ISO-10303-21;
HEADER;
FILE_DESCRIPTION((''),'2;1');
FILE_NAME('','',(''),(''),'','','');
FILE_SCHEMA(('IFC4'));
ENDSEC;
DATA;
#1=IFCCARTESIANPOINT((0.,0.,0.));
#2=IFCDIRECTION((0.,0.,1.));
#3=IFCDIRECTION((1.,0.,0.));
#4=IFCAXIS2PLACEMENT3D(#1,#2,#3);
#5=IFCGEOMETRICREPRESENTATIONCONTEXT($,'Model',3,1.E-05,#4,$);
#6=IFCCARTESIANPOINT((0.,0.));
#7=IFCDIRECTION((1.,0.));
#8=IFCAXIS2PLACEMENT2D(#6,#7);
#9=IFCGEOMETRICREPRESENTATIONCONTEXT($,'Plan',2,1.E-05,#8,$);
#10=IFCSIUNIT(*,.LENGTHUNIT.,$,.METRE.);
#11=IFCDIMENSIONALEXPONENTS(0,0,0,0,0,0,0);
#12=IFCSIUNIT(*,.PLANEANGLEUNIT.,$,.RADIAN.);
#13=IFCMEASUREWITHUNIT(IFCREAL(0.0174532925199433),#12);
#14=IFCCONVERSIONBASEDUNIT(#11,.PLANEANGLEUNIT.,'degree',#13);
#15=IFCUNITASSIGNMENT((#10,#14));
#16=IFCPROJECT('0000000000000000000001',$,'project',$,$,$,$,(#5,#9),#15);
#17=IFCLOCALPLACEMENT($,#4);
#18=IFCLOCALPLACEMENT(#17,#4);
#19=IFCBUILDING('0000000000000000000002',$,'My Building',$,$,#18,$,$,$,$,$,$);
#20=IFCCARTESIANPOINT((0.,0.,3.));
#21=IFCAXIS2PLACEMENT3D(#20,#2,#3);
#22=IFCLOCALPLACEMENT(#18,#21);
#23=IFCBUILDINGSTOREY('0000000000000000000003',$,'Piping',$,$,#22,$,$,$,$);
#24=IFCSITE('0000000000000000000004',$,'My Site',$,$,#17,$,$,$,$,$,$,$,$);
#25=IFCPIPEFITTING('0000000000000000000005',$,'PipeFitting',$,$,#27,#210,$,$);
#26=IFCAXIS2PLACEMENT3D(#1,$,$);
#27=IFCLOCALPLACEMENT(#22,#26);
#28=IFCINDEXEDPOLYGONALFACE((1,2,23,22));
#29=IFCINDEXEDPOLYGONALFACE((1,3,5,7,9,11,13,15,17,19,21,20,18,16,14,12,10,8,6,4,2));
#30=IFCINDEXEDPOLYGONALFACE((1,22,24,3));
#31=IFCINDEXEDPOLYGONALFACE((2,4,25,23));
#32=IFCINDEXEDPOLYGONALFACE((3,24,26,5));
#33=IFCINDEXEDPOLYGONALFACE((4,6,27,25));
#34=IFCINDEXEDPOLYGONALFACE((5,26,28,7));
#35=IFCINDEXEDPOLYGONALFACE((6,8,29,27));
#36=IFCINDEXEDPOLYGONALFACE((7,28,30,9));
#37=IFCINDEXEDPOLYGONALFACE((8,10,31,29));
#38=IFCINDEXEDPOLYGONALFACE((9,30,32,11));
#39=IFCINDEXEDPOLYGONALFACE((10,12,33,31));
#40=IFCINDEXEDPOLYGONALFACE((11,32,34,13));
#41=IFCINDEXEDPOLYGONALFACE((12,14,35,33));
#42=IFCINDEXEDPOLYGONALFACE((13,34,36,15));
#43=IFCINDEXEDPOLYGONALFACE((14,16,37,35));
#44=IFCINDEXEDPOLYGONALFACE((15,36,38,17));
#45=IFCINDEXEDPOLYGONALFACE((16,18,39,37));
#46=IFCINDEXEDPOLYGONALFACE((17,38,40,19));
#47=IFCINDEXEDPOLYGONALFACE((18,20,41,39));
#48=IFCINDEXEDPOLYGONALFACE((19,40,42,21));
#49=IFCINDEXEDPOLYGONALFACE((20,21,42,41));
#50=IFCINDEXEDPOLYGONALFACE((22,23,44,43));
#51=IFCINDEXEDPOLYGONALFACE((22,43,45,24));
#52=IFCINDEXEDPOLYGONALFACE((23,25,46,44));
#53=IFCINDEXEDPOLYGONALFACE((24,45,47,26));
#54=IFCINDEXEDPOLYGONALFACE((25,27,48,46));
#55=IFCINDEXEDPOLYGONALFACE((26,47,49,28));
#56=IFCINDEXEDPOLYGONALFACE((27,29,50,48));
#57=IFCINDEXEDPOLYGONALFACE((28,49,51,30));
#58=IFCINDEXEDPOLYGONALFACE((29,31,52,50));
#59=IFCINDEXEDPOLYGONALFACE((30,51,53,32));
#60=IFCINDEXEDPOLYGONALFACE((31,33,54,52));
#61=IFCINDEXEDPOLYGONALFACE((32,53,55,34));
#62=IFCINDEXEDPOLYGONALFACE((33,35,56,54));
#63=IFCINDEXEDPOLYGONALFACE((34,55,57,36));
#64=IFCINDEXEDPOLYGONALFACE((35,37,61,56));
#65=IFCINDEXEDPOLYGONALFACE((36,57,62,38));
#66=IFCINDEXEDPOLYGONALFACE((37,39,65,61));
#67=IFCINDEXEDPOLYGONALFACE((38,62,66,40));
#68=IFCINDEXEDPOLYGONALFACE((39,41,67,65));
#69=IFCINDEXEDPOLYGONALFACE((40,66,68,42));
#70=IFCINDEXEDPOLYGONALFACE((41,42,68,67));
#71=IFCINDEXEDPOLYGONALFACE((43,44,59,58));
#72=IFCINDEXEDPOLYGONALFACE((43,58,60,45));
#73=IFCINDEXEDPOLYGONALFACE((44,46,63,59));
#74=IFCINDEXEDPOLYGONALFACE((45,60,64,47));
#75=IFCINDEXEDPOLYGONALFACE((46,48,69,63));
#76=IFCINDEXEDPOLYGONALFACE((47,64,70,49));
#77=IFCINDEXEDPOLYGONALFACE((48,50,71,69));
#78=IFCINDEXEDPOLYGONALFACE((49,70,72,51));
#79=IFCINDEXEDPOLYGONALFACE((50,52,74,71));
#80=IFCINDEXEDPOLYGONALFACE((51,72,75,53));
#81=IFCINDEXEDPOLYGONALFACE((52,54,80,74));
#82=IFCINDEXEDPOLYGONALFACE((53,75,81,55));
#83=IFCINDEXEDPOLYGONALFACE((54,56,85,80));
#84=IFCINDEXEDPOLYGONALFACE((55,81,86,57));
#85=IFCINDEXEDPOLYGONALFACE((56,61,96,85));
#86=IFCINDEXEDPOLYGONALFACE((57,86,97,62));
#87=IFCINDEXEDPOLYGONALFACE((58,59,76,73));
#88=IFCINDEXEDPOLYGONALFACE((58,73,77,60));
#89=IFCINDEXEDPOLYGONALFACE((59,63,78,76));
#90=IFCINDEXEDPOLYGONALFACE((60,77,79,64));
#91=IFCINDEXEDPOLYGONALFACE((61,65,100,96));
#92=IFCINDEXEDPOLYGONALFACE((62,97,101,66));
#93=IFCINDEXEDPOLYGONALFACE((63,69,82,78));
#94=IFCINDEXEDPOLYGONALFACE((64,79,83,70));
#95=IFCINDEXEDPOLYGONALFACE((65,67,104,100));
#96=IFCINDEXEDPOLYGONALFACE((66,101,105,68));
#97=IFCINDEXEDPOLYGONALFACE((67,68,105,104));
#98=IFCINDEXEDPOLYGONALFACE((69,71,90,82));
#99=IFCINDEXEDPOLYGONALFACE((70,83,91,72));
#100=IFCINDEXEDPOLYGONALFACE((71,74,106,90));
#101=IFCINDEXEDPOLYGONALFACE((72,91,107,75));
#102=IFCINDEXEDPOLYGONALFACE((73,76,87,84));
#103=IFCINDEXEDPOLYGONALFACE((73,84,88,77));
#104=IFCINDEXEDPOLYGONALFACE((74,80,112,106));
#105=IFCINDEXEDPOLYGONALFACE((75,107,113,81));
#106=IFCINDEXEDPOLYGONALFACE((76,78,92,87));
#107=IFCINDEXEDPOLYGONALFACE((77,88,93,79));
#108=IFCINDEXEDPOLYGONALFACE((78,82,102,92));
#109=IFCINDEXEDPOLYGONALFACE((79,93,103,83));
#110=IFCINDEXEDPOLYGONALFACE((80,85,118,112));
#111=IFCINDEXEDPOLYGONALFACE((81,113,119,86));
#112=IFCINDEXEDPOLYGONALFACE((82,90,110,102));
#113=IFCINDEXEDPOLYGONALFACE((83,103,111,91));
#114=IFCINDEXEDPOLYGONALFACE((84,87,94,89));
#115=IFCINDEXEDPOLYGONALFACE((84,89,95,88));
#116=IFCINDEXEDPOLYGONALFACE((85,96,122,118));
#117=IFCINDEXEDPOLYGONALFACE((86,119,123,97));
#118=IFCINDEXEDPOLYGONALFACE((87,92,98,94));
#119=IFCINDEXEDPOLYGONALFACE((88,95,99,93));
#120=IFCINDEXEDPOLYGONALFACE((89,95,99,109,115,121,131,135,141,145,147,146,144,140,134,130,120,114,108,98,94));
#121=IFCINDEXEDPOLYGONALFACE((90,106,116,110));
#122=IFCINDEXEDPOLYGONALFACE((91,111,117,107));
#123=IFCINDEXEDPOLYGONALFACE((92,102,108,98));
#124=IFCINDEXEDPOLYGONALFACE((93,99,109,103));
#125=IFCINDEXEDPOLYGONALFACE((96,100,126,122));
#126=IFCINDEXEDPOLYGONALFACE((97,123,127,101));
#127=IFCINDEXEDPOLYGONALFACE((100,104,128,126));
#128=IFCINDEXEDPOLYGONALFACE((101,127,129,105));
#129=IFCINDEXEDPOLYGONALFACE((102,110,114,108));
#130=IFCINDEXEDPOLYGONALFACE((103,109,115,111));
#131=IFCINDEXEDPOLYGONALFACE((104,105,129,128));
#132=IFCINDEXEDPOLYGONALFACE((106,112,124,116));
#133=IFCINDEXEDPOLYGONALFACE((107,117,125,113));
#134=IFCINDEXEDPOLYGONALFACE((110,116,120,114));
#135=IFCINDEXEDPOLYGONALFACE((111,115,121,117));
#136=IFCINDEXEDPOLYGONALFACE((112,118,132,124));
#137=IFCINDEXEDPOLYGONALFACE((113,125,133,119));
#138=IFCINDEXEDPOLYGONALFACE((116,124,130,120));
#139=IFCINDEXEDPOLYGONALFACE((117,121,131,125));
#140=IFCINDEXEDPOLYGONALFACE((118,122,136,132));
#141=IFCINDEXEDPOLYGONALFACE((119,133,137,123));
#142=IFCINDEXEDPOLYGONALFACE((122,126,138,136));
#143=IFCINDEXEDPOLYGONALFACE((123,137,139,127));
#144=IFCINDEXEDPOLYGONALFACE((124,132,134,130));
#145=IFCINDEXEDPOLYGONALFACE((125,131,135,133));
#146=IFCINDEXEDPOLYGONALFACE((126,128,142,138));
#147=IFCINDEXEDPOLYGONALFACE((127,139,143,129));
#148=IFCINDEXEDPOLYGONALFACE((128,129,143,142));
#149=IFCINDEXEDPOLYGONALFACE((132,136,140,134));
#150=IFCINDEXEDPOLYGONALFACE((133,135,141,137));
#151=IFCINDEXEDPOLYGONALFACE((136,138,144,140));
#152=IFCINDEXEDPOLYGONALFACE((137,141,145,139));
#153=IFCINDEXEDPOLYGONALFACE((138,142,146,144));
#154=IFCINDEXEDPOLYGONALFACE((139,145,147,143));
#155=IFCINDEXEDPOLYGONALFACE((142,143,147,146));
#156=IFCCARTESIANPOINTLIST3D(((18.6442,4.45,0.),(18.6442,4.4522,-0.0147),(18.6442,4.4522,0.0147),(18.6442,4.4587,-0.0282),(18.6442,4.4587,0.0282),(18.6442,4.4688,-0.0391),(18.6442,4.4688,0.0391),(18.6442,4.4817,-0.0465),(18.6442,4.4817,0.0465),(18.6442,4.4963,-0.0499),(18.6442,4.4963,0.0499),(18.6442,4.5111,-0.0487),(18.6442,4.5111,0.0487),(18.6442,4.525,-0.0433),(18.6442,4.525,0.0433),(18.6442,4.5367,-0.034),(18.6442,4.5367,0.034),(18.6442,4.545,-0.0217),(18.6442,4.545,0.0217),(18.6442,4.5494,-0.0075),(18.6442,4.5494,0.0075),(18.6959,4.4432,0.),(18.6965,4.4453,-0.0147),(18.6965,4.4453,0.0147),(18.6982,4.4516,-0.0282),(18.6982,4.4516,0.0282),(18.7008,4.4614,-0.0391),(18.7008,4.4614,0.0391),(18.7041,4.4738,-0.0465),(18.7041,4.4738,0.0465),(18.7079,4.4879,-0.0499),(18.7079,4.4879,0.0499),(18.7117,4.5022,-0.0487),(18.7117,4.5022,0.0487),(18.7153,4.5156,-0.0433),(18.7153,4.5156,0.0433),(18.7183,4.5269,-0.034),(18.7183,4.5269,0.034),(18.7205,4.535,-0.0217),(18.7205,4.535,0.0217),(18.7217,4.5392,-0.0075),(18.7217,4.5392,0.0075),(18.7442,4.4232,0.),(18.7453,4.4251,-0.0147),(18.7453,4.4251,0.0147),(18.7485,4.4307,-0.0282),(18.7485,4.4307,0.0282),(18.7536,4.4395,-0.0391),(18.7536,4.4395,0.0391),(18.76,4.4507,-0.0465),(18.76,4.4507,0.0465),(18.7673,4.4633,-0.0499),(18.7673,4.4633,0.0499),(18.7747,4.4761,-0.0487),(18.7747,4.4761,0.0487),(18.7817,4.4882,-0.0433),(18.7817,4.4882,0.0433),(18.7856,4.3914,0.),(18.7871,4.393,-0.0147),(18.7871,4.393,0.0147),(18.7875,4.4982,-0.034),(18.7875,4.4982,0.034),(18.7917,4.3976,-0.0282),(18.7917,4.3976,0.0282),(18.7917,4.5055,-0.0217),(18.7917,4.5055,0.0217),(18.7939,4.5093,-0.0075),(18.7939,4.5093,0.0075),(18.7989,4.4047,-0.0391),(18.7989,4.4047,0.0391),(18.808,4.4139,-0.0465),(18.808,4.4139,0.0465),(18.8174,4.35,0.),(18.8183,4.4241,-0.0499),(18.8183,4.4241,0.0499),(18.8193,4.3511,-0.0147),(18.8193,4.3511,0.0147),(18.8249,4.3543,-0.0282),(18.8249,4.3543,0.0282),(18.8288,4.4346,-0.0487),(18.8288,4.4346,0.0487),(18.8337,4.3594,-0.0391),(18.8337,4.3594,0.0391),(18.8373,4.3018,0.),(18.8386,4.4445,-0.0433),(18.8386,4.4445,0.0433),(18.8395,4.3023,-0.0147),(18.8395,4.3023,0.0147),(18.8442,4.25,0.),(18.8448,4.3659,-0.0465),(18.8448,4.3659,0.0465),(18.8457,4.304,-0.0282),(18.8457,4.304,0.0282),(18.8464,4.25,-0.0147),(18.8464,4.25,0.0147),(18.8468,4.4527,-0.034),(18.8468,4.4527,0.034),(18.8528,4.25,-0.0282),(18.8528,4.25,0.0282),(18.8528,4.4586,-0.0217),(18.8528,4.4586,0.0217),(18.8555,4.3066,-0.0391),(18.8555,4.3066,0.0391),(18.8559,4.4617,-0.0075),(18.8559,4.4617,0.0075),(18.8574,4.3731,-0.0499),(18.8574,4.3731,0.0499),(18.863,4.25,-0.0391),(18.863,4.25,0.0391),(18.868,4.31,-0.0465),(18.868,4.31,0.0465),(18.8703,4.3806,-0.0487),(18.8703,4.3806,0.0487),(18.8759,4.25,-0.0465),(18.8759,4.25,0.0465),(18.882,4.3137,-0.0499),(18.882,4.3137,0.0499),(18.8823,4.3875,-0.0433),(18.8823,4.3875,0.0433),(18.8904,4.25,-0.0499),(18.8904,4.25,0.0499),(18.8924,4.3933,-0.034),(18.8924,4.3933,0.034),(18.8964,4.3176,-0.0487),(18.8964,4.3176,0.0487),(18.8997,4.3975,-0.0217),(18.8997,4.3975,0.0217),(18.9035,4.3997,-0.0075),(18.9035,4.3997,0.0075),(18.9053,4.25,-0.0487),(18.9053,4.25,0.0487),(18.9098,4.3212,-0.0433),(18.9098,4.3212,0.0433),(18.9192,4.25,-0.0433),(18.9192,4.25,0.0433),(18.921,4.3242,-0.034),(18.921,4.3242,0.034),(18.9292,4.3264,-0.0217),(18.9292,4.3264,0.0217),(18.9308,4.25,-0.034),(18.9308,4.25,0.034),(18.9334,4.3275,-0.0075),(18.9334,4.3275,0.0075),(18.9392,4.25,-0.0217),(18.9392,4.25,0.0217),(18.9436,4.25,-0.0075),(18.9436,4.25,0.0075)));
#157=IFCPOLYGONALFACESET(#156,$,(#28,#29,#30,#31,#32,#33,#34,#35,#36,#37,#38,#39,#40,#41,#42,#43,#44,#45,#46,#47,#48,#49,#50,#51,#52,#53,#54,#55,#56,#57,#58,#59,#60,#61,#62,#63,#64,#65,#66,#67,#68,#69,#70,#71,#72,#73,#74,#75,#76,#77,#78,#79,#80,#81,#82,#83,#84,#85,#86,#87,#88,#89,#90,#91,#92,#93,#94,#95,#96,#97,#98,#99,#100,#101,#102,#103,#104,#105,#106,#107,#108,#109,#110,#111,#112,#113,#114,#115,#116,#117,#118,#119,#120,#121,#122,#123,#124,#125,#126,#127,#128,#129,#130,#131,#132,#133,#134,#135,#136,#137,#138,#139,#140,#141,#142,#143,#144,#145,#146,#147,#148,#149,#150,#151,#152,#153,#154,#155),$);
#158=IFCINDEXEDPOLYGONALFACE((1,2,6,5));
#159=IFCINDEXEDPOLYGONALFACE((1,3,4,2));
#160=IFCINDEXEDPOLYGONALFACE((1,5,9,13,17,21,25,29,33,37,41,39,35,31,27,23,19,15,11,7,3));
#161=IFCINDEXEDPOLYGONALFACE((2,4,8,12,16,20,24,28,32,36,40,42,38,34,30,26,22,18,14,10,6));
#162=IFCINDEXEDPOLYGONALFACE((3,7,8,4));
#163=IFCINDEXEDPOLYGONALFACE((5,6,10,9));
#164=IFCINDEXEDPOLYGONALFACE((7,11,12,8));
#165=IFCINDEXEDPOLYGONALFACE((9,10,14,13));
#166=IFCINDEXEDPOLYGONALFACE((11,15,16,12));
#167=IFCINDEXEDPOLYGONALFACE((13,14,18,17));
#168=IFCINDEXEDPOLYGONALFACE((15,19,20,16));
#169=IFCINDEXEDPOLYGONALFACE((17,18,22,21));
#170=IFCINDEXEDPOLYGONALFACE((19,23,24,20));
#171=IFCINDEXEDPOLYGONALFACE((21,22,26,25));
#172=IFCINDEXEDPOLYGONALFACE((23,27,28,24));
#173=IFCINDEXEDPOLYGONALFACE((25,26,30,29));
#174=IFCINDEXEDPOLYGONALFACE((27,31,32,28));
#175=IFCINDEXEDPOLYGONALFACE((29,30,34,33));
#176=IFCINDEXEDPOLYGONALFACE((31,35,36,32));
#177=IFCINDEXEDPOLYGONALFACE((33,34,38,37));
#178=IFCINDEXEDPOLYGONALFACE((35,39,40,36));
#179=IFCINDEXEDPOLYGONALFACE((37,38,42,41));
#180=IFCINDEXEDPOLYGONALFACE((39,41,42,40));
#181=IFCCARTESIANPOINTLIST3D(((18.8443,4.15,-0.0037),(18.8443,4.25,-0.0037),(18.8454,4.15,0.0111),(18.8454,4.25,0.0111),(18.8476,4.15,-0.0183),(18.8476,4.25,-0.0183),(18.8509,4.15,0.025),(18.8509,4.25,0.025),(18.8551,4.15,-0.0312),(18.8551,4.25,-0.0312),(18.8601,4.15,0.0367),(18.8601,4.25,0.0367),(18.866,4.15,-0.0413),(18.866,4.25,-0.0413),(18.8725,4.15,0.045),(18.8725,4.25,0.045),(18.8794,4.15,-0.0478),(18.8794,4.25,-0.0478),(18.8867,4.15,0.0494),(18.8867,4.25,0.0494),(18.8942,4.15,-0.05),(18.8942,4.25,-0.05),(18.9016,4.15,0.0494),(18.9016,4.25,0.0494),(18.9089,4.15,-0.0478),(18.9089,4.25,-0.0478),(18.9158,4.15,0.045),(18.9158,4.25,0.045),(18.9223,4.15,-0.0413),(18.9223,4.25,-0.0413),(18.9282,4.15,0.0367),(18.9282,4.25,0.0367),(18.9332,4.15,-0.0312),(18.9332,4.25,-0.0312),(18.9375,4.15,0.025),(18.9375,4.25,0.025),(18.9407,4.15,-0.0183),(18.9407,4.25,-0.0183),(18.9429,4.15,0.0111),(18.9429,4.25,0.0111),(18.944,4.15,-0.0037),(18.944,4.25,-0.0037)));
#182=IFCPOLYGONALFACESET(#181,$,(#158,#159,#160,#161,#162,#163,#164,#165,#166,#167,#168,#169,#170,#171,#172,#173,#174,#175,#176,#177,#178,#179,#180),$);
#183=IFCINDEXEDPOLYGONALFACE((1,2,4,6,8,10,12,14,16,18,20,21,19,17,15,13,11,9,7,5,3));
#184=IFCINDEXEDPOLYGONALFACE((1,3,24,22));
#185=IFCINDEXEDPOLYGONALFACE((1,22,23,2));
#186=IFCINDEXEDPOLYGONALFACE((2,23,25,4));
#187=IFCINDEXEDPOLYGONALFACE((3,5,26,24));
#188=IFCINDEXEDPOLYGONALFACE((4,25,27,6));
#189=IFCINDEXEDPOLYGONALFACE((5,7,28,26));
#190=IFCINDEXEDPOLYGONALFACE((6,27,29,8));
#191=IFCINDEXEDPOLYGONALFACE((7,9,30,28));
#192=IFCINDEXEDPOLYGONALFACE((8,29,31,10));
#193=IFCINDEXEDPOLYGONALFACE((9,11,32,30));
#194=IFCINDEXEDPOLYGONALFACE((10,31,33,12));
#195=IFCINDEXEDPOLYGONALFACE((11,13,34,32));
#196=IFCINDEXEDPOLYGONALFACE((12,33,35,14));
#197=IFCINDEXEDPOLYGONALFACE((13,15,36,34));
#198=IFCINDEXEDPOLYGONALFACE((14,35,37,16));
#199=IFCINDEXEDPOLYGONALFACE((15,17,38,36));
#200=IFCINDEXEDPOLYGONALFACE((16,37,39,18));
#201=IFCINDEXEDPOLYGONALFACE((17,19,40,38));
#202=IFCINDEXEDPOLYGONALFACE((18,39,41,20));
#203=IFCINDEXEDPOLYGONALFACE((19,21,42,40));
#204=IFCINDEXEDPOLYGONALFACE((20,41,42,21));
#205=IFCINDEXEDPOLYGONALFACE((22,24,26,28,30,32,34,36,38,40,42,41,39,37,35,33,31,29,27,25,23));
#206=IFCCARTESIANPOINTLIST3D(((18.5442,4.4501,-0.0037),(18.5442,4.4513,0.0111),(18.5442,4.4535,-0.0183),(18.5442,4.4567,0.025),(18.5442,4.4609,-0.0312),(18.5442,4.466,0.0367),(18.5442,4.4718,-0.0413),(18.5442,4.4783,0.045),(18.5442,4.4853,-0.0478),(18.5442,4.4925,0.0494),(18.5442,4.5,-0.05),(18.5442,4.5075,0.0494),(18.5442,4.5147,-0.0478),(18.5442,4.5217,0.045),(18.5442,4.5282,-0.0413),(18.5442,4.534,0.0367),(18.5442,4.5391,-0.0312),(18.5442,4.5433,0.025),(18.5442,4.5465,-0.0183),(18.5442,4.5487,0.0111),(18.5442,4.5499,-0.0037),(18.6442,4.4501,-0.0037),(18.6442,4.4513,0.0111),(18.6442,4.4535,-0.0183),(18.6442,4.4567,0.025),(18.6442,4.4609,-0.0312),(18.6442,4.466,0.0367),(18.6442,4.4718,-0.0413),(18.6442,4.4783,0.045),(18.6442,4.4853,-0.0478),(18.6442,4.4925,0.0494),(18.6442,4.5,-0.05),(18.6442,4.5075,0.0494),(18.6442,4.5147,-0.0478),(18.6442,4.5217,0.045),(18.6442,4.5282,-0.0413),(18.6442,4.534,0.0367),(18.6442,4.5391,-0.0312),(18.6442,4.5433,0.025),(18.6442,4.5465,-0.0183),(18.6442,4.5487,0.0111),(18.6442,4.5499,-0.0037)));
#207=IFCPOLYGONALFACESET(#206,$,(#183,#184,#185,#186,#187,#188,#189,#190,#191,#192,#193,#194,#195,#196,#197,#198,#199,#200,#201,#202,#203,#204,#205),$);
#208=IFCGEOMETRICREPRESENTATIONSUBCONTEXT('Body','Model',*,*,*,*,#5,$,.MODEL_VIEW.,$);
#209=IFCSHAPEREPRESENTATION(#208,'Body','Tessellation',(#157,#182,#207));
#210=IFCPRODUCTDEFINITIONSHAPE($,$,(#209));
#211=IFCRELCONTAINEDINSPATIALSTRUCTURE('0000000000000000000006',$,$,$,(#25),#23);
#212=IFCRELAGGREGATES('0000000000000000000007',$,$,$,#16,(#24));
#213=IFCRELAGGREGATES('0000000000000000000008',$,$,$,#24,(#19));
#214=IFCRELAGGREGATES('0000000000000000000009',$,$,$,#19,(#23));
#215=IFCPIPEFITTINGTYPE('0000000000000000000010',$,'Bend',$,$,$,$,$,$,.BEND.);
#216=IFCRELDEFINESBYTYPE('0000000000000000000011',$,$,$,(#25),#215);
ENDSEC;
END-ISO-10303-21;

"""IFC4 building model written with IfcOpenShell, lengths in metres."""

from ifc_helpers import new_model, entity, si_unit, converted_unit, frame, origin_with_axes, origin_2d_with_axis, place, context, subcontext, project, spatial, circle, extrude, source, transform, mapped, type_object, type_shapes, element, save


model = new_model("IFC4")

# Units and contexts
model_context = context("Model", 3, precision=1e-05, world=origin_with_axes())
plan_context = context("Plan", 2, precision=1e-05, world=origin_2d_with_axis())
body_context = subcontext(model_context, "Body", "Model", "MODEL_VIEW")
ifc_project = project(units=[si_unit("LENGTHUNIT", "METRE"), converted_unit("PLANEANGLEUNIT", "degree", entity("IfcReal", 0.0174532925199433), si_unit("PLANEANGLEUNIT", "RADIAN"), dimensions=[0, 0, 0, 0, 0, 0, 0])], contexts=[model_context, plan_context])

# Site, building, storey
site_placement = place(None, origin_with_axes())
site = spatial("IfcSite", under=ifc_project, at=site_placement, Name="My Site")
building_placement = place(site_placement, origin_with_axes())
building = spatial("IfcBuilding", under=site, at=building_placement, Name="My Building")
storey_placement = place(building_placement, frame((0.0, 0.0, 3.0), z_axis=(0.0, 0.0, 1.0), x_axis=(1.0, 0.0, 0.0)))
storey = spatial("IfcBuildingStorey", under=building, at=storey_placement, Name="Piping")

# Shared definitions
pipe_fitting_type = type_object("IfcPipeFittingType", Name="Bend", PredefinedType="BEND")
shared_shape = source(origin_with_axes(), body_context, "Body", "SolidModel", [
    entity("IfcSweptDiskSolid", entity("IfcIndexedPolyCurve", entity("IfcCartesianPointList3D", [[0.0, 0.0, -0.1], [0.0, -0.0732, -0.2768], [0.0, -0.25, -0.35]]), [entity("IfcArcIndex", [1, 2, 3])]), 0.05),
    extrude(circle(Radius=0.05), origin_with_axes(), (0.0, 0.0, -1.0), 0.1),
    extrude(circle(Radius=0.05), frame((0.0, -0.25, -0.35), z_axis=(0.0, -1.0, 0.0), x_axis=(1.0, 0.0, 0.0)), (0.0, 0.0, 1.0), 0.1),
])
type_shapes(pipe_fitting_type, [shared_shape])

# Pipe fitting
for number, where, z_axis, x_axis, name in (
    (1, (18.8942, 4.15, 0.0), (0.0, -1.0, 0.0), (0.0, 0.0, -1.0), "PipeFitting"),
):
    element("IfcPipeFitting", number, at=place(storey_placement, frame(where, z_axis=z_axis, x_axis=x_axis)), inside=storey, type_object=pipe_fitting_type, Name=name, context=body_context, shape_type="MappedRepresentation", body=[
        mapped(shared_shape, transform((0.0, 0.0, 0.0), x_axis=(1.0, 0.0, 0.0), y_axis=(0.0, 1.0, 0.0), z_axis=(0.0, 0.0, 1.0), scale=1.0)),
    ])

save(model, "model.ifc")
